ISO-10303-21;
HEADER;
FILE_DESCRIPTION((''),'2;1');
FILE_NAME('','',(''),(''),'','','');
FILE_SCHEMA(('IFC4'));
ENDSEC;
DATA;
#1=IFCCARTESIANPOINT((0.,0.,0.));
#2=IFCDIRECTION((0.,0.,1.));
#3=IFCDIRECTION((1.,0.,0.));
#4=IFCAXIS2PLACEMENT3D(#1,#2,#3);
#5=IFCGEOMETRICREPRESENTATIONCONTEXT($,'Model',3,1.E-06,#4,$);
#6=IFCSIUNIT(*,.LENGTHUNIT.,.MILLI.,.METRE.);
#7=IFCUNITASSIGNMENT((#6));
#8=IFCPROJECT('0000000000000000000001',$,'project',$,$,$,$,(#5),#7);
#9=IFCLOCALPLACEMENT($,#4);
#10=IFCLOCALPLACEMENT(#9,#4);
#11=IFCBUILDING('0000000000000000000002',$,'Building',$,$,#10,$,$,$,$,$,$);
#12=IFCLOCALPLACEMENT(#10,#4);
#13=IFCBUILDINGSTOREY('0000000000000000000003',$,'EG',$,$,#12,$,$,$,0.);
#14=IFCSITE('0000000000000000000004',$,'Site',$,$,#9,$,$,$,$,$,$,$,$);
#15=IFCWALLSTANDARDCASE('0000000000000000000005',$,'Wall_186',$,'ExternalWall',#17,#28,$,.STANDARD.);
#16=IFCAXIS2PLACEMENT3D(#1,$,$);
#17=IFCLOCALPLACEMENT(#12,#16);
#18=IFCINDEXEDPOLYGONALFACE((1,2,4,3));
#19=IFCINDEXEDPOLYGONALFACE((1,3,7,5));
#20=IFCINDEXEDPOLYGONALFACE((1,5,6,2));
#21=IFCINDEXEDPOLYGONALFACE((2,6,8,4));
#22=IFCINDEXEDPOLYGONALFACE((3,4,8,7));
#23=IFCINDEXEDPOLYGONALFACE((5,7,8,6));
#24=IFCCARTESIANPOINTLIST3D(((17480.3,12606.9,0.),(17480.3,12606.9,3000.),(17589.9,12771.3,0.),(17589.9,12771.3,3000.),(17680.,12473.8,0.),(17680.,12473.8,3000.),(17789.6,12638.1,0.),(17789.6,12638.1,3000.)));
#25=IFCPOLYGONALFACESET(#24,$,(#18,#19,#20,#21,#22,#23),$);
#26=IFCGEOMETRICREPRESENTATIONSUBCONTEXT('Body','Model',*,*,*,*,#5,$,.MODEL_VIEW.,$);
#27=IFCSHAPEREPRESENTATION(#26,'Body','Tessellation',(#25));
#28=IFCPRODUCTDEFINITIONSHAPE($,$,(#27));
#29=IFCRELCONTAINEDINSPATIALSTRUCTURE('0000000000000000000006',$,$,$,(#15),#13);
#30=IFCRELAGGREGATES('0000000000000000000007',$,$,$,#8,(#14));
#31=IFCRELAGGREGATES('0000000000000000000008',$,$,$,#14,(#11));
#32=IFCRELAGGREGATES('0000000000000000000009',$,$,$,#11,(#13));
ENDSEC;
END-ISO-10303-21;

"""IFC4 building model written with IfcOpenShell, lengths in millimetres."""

from ifc_helpers import new_model, si_unit, frame, origin_with_axes, place, context, subcontext, project, spatial, rectangle, extrude, element, save


model = new_model("IFC4")

# Units and contexts
model_context = context("Model", 3, precision=1e-06, world=origin_with_axes())
body_context = subcontext(model_context, "Body", "Model", "MODEL_VIEW")
ifc_project = project(units=[si_unit("LENGTHUNIT", "METRE", prefix="MILLI")], contexts=[model_context])

# Site, building, storey
site_placement = place(None, origin_with_axes())
site = spatial("IfcSite", under=ifc_project, at=site_placement, Name="Site")
building_placement = place(site_placement, origin_with_axes())
building = spatial("IfcBuilding", under=site, at=building_placement, Name="Building")
storey_placement = place(building_placement, origin_with_axes())
storey = spatial("IfcBuildingStorey", under=building, at=storey_placement, Name="EG", Elevation=0.0)

# Wall
wall_1_placement = place(storey_placement, origin_with_axes())
element("IfcWallStandardCase", 1, at=wall_1_placement, inside=storey, Name="Wall_186", ObjectType="ExternalWall", PredefinedType="STANDARD", context=body_context, shape_type="SweptSolid", body=[
    extrude(rectangle(XDim=197.6, YDim=240.0), frame((17634.9, 12622.5, 0.0), z_axis=(0.0, 0.0, 1.0), x_axis=(-0.5547, -0.83205, 0.0)), (0.0, 0.0, 1.0), 3000.0),
])

save(model, "model.ifc")
